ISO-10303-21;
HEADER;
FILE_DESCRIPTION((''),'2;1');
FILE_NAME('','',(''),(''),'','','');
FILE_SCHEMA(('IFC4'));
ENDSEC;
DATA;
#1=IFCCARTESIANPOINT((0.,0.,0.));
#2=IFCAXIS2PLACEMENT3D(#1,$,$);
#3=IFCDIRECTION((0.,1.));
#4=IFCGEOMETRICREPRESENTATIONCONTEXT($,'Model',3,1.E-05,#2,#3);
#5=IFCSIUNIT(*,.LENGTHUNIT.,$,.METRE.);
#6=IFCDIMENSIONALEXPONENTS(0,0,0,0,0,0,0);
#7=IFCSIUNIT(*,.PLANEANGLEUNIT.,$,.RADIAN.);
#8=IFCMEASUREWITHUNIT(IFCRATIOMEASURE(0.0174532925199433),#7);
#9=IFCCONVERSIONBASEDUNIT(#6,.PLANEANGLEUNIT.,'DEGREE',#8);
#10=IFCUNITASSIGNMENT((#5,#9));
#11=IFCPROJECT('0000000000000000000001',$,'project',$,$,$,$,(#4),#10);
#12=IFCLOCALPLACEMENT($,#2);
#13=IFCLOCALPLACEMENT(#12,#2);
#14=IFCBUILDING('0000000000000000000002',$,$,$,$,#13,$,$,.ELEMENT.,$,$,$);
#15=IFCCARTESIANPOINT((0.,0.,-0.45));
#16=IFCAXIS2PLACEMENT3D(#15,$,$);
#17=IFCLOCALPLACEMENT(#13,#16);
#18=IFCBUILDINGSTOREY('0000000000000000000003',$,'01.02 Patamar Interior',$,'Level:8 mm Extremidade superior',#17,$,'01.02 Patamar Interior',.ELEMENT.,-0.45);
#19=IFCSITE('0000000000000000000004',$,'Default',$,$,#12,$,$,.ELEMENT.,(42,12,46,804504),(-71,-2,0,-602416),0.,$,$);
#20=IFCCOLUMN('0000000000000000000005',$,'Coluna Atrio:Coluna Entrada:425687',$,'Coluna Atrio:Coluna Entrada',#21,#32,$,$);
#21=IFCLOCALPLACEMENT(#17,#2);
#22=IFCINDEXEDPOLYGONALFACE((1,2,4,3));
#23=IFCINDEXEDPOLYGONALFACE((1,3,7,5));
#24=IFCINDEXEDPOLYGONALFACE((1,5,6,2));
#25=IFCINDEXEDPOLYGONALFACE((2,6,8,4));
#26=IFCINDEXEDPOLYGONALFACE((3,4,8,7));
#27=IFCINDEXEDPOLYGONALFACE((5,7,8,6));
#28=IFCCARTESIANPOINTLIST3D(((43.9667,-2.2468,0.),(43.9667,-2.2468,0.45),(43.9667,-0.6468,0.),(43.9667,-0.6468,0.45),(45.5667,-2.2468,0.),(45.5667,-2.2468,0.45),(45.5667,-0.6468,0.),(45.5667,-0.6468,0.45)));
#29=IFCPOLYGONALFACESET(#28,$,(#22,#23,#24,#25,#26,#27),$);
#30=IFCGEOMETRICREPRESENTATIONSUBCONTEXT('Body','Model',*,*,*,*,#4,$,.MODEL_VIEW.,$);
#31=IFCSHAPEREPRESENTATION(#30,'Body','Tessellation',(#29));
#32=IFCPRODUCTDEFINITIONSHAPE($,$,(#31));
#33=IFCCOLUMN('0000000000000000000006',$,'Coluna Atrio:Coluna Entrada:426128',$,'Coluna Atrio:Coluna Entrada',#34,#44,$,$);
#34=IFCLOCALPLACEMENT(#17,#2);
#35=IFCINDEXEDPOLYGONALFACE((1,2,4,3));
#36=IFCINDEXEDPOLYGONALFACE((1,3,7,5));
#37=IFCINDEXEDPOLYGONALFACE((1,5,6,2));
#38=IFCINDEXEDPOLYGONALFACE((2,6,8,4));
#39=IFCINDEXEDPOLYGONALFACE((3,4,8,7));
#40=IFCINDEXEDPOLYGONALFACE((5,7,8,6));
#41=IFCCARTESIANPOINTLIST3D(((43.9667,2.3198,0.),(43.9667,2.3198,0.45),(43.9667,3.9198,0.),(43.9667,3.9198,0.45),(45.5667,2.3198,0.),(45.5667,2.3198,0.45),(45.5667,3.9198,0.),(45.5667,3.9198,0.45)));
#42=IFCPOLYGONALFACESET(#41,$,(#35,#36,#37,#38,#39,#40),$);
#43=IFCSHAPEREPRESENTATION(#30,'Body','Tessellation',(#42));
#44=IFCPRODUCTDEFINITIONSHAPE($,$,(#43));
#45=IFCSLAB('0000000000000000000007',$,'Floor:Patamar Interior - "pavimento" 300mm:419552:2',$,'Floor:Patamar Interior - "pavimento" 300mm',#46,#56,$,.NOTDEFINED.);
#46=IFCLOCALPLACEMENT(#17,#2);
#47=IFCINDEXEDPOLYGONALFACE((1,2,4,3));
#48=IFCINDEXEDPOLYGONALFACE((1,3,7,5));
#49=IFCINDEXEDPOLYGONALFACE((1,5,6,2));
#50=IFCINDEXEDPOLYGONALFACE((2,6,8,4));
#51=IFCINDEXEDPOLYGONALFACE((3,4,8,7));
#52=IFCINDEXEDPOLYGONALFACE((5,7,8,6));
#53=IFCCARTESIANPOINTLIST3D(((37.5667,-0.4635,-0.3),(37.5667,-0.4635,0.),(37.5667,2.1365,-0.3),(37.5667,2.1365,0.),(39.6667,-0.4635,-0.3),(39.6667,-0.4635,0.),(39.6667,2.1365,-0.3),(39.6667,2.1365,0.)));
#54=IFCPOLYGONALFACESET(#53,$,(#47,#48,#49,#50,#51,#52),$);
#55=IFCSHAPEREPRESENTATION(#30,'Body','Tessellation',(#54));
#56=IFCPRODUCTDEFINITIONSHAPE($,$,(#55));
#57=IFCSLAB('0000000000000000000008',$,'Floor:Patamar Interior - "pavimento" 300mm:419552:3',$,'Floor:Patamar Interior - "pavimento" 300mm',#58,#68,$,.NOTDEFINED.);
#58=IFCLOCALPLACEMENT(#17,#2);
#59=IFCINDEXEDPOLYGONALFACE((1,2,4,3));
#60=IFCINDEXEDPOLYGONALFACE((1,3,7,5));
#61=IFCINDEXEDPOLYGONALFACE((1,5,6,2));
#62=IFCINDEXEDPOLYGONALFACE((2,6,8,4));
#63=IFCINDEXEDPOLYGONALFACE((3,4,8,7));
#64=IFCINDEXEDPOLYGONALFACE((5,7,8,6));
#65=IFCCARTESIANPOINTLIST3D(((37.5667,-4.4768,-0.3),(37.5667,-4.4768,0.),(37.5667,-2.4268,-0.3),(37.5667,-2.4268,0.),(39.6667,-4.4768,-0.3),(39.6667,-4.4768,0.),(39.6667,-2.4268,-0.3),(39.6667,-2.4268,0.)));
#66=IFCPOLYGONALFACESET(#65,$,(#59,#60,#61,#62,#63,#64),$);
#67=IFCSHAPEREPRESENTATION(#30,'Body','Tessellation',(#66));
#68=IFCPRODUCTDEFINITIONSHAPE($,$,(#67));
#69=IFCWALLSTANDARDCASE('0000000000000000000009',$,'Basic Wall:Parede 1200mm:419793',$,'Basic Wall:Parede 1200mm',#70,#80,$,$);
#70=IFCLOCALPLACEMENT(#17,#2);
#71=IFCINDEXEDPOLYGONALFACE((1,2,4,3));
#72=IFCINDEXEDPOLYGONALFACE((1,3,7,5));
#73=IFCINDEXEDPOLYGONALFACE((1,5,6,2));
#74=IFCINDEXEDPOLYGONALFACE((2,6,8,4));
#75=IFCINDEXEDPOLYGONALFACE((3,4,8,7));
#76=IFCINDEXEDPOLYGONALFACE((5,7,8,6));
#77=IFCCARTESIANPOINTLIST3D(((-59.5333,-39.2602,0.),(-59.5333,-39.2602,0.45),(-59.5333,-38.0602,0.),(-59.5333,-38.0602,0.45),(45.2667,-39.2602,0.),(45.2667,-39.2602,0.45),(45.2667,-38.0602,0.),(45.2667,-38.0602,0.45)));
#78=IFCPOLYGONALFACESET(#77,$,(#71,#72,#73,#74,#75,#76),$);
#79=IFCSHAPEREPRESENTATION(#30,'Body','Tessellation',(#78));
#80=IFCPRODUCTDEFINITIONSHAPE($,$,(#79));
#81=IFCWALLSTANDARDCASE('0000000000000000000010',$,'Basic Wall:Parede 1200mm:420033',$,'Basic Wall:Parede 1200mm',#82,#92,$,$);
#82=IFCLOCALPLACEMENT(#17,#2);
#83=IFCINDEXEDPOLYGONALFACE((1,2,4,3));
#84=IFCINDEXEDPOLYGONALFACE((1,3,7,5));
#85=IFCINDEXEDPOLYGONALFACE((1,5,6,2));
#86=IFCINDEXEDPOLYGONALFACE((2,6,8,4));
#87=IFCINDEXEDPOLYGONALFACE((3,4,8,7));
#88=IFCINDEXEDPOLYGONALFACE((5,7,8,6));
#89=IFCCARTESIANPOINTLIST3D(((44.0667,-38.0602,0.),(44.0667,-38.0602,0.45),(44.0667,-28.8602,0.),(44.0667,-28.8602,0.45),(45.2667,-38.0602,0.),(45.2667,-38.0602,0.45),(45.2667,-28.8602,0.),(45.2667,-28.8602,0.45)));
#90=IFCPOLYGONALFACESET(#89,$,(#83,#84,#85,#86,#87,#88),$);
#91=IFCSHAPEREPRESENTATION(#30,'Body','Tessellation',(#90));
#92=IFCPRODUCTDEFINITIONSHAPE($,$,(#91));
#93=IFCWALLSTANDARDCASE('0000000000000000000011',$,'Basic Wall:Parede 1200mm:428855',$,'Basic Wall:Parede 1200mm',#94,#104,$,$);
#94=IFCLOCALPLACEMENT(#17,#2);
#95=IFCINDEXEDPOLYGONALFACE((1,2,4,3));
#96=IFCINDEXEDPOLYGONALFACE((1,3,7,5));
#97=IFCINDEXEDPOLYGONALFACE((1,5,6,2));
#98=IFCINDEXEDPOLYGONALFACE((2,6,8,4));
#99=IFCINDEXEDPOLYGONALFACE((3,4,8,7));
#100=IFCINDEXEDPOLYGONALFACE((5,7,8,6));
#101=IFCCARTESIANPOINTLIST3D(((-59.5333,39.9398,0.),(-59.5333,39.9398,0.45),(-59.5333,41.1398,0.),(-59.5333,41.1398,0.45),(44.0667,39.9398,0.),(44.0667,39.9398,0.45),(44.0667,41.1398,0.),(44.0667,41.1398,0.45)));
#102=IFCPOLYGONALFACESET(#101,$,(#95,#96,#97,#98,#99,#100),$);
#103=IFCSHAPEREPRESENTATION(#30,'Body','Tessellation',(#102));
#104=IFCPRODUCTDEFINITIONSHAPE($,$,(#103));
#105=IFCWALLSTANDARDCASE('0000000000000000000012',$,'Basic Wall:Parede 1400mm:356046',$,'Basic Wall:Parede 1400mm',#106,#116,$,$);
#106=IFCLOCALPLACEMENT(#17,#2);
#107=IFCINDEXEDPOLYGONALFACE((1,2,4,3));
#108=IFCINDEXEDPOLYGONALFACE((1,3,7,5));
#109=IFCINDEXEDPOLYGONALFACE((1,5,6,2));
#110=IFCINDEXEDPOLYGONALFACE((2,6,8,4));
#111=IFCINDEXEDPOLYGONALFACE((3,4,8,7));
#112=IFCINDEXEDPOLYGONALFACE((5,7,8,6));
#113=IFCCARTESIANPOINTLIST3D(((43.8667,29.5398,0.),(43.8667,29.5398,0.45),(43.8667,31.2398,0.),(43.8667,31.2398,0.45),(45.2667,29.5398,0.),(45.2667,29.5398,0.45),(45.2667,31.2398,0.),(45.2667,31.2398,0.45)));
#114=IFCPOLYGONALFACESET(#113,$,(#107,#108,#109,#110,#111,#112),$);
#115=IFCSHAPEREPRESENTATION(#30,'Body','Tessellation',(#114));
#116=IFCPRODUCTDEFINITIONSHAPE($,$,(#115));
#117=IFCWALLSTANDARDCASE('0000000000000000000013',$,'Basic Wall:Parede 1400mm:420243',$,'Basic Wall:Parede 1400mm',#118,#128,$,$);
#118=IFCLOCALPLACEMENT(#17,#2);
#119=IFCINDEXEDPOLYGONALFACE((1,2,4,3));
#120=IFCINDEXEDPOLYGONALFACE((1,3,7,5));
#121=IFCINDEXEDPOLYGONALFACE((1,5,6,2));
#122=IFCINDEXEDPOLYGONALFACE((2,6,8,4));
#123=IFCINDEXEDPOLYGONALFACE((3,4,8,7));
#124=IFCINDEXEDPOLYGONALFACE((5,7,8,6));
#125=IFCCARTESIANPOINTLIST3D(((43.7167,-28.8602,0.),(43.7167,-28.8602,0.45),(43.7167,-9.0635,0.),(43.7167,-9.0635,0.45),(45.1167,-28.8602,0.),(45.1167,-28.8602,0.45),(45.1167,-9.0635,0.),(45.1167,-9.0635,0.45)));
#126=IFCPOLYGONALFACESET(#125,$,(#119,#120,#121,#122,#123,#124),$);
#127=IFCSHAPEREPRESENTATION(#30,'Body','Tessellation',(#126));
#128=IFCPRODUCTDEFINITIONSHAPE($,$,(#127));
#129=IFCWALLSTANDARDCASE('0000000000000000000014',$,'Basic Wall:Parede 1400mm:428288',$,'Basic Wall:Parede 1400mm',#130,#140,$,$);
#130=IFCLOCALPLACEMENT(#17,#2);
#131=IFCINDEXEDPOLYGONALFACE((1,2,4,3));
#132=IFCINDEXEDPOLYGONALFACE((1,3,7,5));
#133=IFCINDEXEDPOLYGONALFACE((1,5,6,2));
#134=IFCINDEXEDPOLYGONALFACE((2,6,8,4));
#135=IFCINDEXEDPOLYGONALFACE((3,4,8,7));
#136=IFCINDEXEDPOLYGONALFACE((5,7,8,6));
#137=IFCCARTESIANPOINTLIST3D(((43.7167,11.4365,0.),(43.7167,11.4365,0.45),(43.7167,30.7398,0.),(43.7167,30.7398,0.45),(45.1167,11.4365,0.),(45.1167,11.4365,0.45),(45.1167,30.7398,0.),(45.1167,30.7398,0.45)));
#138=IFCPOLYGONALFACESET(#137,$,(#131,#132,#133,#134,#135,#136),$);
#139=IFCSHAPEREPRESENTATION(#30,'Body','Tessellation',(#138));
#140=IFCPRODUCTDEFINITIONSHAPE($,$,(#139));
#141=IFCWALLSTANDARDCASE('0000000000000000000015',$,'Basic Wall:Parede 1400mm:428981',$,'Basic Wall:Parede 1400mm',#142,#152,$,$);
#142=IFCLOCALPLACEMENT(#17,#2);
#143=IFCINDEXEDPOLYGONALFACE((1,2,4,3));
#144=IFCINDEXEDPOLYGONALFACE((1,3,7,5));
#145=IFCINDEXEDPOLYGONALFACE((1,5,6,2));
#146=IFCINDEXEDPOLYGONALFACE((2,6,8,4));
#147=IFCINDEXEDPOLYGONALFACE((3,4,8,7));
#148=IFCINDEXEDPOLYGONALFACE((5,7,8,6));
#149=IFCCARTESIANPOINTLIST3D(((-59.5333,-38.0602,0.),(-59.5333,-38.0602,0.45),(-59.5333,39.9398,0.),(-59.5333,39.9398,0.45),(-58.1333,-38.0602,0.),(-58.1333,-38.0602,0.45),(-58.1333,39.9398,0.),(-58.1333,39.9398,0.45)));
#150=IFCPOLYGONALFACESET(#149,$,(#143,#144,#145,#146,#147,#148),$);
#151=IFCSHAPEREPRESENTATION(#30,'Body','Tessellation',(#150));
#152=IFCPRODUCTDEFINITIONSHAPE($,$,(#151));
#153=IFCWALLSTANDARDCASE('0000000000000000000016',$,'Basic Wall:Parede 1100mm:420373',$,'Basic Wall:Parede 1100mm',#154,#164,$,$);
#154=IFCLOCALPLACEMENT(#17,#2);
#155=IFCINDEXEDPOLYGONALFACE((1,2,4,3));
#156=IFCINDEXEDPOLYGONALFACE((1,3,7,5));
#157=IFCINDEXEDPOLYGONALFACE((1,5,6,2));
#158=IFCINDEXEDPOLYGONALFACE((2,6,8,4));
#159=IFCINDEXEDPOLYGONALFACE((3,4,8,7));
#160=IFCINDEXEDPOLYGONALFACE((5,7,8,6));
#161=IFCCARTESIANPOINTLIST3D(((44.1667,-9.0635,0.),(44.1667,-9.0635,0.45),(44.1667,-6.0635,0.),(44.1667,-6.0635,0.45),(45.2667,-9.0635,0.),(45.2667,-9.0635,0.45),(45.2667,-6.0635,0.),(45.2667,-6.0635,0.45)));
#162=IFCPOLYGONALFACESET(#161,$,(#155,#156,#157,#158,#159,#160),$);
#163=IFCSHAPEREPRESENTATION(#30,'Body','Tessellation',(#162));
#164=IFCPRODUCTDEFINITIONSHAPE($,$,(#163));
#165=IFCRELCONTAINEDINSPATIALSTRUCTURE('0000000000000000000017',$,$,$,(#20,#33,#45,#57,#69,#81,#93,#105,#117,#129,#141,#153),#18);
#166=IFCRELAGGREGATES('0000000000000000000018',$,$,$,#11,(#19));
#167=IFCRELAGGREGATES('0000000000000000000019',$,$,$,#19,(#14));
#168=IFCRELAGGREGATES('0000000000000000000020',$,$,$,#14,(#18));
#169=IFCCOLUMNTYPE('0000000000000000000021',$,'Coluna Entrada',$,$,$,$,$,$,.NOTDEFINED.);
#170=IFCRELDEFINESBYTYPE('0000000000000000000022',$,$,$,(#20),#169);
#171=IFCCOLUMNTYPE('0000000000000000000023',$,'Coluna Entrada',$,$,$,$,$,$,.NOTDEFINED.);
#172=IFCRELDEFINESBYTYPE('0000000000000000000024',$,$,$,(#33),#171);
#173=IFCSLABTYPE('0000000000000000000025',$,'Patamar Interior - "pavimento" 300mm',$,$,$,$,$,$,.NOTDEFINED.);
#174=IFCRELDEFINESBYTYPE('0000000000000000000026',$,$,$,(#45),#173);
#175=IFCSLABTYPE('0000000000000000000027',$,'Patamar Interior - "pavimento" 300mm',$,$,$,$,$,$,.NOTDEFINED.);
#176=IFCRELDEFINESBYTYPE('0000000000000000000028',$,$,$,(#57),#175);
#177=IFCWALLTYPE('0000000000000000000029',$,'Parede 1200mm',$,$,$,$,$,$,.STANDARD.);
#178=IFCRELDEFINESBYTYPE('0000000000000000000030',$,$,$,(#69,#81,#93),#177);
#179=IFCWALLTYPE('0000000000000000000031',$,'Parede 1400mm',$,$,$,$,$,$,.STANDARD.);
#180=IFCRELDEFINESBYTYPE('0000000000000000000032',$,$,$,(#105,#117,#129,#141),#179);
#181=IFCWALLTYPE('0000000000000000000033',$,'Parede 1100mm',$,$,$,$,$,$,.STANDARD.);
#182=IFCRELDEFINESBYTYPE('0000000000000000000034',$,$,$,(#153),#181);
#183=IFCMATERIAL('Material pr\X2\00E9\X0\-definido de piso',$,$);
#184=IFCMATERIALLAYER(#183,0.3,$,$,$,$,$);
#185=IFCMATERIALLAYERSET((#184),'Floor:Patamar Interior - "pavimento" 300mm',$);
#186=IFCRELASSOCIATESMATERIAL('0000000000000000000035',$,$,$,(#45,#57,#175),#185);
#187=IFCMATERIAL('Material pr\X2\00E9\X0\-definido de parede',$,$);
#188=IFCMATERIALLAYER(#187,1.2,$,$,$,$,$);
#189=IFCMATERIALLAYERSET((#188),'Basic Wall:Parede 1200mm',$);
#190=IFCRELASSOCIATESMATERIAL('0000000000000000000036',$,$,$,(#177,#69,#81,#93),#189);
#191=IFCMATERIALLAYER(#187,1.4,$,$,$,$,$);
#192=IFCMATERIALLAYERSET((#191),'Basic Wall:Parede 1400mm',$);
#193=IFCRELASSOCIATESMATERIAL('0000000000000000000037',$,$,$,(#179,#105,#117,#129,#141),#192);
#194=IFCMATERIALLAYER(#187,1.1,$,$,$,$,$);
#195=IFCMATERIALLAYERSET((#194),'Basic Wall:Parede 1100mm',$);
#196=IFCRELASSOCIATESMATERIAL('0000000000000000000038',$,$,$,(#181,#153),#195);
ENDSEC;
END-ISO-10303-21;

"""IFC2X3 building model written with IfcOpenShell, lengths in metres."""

from ifc_helpers import new_model, entity, si_unit, converted_unit, direction, frame, frame_2d, origin, origin_2d_with_axis, place, context, subcontext, project, spatial, rectangle, extrude, clip, halfspace, source, transform, mapped, material, layer, layer_set, layer_usage, type_object, type_shapes, element, save


model = new_model("IFC2X3")

# Units and contexts
model_context = context("Model", 3, precision=1e-05, world=origin(), true_north=direction((0.0, 1.0)))
body_context = subcontext(model_context, "Body", "Model", "MODEL_VIEW")
ifc_project = project(units=[si_unit("LENGTHUNIT", "METRE"), converted_unit("PLANEANGLEUNIT", "DEGREE", entity("IfcRatioMeasure", 0.0174532925199433), si_unit("PLANEANGLEUNIT", "RADIAN"), dimensions=[0, 0, 0, 0, 0, 0, 0])], contexts=[model_context])

# Site, building, storey
site_placement = place(None, origin())
site = spatial("IfcSite", under=ifc_project, at=site_placement, Name="Default", CompositionType="ELEMENT", RefLatitude=(42, 12, 46, 804504), RefLongitude=(-71, -2, 0, -602416), RefElevation=0.0)
building_placement = place(site_placement, origin())
building = spatial("IfcBuilding", under=site, at=building_placement, CompositionType="ELEMENT")
storey_placement = place(building_placement, frame((0.0, 0.0, -0.45)))
storey = spatial("IfcBuildingStorey", under=building, at=storey_placement, Name="01.02 Patamar Interior", ObjectType="Level:8 mm Extremidade superior", LongName="01.02 Patamar Interior", CompositionType="ELEMENT", Elevation=-0.45)

# Columns
column_type_1 = type_object("IfcColumnType", Name="Coluna Entrada", PredefinedType="NOTDEFINED")
shared_shape_1 = source(origin(), body_context, "Body", "SweptSolid", [
    extrude(rectangle(XDim=1.6, YDim=1.6, at=origin_2d_with_axis()), frame((0.0, 0.0, -0.45), z_axis=(0.0, 0.0, 1.0), x_axis=(0.0, -1.0, 0.0)), (0.0, 0.0, 1.0), 0.45),
])
type_shapes(column_type_1, [shared_shape_1])
column_1_placement = place(storey_placement, frame((44.7667, -1.4468, 0.45)))
element("IfcColumn", 1, at=column_1_placement, inside=storey, type_object=column_type_1, Name="Coluna Atrio:Coluna Entrada:425687", ObjectType="Coluna Atrio:Coluna Entrada", context=body_context, shape_type="MappedRepresentation", body=[
    mapped(shared_shape_1, transform((0.0, 0.0, 0.0), scale=1.0)),
])
column_type_2 = type_object("IfcColumnType", Name="Coluna Entrada", PredefinedType="NOTDEFINED")
shared_shape_2 = source(origin(), body_context, "Body", "SweptSolid", [
    extrude(rectangle(XDim=1.6, YDim=1.6, at=origin_2d_with_axis()), frame((0.0, 0.0, -0.45), z_axis=(0.0, 0.0, 1.0), x_axis=(0.0, -1.0, 0.0)), (0.0, 0.0, 1.0), 0.45),
])
type_shapes(column_type_2, [shared_shape_2])
column_2_placement = place(storey_placement, frame((44.7667, 3.1198, 0.45)))
element("IfcColumn", 2, at=column_2_placement, inside=storey, type_object=column_type_2, Name="Coluna Atrio:Coluna Entrada:426128", ObjectType="Coluna Atrio:Coluna Entrada", context=body_context, shape_type="MappedRepresentation", body=[
    mapped(shared_shape_2, transform((0.0, 0.0, 0.0), scale=1.0)),
])

# Slabs
ifc_material_1 = material(Name="Material pré-definido de piso")
ifc_layer_1 = layer(ifc_material_1, 0.3)
ifc_layer_set_1 = layer_set([ifc_layer_1], Name="Floor:Patamar Interior - \"pavimento\" 300mm")
ifc_layer_usage_1 = layer_usage(ifc_layer_set_1, "AXIS3", "POSITIVE", 0.0)
slab_type_1 = type_object("IfcSlabType", Name="Patamar Interior - \"pavimento\" 300mm", PredefinedType="NOTDEFINED")
slab_1_placement = place(storey_placement, frame((37.5667, -4.4768, -0.3)))
element("IfcSlab", 3, at=slab_1_placement, inside=storey, type_object=slab_type_1, material=ifc_layer_usage_1, Name="Floor:Patamar Interior - \"pavimento\" 300mm:419552:2", ObjectType="Floor:Patamar Interior - \"pavimento\" 300mm", PredefinedType="NOTDEFINED", context=body_context, shape_type="SweptSolid", body=[
    extrude(rectangle(XDim=2.6, YDim=2.1, at=frame_2d((0.0, 0.0), x_axis=(0.0, -1.0))), frame((1.05, 5.3133, 0.3), z_axis=(0.0, 0.0, -1.0), x_axis=(-1.0, 0.0, 0.0)), (0.0, 0.0, 1.0), 0.3),
])
slab_type_2 = type_object("IfcSlabType", Name="Patamar Interior - \"pavimento\" 300mm", PredefinedType="NOTDEFINED", material=ifc_layer_set_1)
slab_2_placement = place(storey_placement, frame((37.5667, -4.4768, -0.3)))
element("IfcSlab", 4, at=slab_2_placement, inside=storey, type_object=slab_type_2, material=ifc_layer_usage_1, Name="Floor:Patamar Interior - \"pavimento\" 300mm:419552:3", ObjectType="Floor:Patamar Interior - \"pavimento\" 300mm", PredefinedType="NOTDEFINED", context=body_context, shape_type="SweptSolid", body=[
    extrude(rectangle(XDim=2.05, YDim=2.1, at=frame_2d((0.0, -4.2883), x_axis=(0.0, -1.0))), frame((1.05, 5.3133, 0.3), z_axis=(0.0, 0.0, -1.0), x_axis=(-1.0, 0.0, 0.0)), (0.0, 0.0, 1.0), 0.3),
])

# Walls
ifc_material_2 = material(Name="Material pré-definido de parede")
ifc_layer_2 = layer(ifc_material_2, 1.2)
ifc_layer_set_2 = layer_set([ifc_layer_2], Name="Basic Wall:Parede 1200mm")
ifc_layer_usage_2 = layer_usage(ifc_layer_set_2, "AXIS2", "NEGATIVE", 0.6)
wall_type_1 = type_object("IfcWallType", Name="Parede 1200mm", PredefinedType="STANDARD", material=ifc_layer_set_2)
wall_1_placement = place(storey_placement, frame((45.2667, -38.6602, 0.0), z_axis=(0.0, 0.0, 1.0), x_axis=(-1.0, 0.0, 0.0)))
element("IfcWallStandardCase", 5, at=wall_1_placement, inside=storey, type_object=wall_type_1, material=ifc_layer_usage_2, Name="Basic Wall:Parede 1200mm:419793", ObjectType="Basic Wall:Parede 1200mm", context=body_context, shape_type="Clipping", body=[
    clip(extrude(rectangle(XDim=104.8, YDim=1.2, at=frame_2d((52.4, 0.0), x_axis=(-1.0, 0.0))), origin(), (0.0, 0.0, 1.0), 0.45), halfspace(frame((0.0, 0.0, -2.4)), True)),
])
ifc_layer_usage_3 = layer_usage(ifc_layer_set_2, "AXIS2", "POSITIVE", -0.6)
wall_2_placement = place(storey_placement, frame((44.6667, -38.0602, 0.0), z_axis=(0.0, 0.0, 1.0), x_axis=(0.0, 1.0, 0.0)))
element("IfcWallStandardCase", 6, at=wall_2_placement, inside=storey, type_object=wall_type_1, material=ifc_layer_usage_3, Name="Basic Wall:Parede 1200mm:420033", ObjectType="Basic Wall:Parede 1200mm", context=body_context, shape_type="Clipping", body=[
    clip(extrude(rectangle(XDim=9.2, YDim=1.2, at=frame_2d((4.6, 0.0), x_axis=(-1.0, 0.0))), origin(), (0.0, 0.0, 1.0), 0.45), halfspace(frame((0.0, 0.0, -2.4)), True)),
])
ifc_layer_usage_4 = layer_usage(ifc_layer_set_2, "AXIS2", "POSITIVE", -0.6)
wall_3_placement = place(storey_placement, frame((44.0667, 40.5398, 0.0), z_axis=(0.0, 0.0, 1.0), x_axis=(-1.0, 0.0, 0.0)))
element("IfcWallStandardCase", 7, at=wall_3_placement, inside=storey, type_object=wall_type_1, material=ifc_layer_usage_4, Name="Basic Wall:Parede 1200mm:428855", ObjectType="Basic Wall:Parede 1200mm", context=body_context, shape_type="Clipping", body=[
    clip(extrude(rectangle(XDim=103.6, YDim=1.2, at=frame_2d((51.8, 0.0), x_axis=(-1.0, 0.0))), origin(), (0.0, 0.0, 1.0), 0.45), halfspace(frame((0.0, 0.0, -2.4)), True)),
])
ifc_layer_3 = layer(ifc_material_2, 1.4)
ifc_layer_set_3 = layer_set([ifc_layer_3], Name="Basic Wall:Parede 1400mm")
ifc_layer_usage_5 = layer_usage(ifc_layer_set_3, "AXIS2", "POSITIVE", -0.7)
wall_type_2 = type_object("IfcWallType", Name="Parede 1400mm", PredefinedType="STANDARD", material=ifc_layer_set_3)
wall_4_placement = place(storey_placement, frame((44.5667, 31.2398, 0.0), z_axis=(0.0, 0.0, 1.0), x_axis=(0.0, -1.0, 0.0)))
element("IfcWallStandardCase", 8, at=wall_4_placement, inside=storey, type_object=wall_type_2, material=ifc_layer_usage_5, Name="Basic Wall:Parede 1400mm:356046", ObjectType="Basic Wall:Parede 1400mm", context=body_context, shape_type="Clipping", body=[
    clip(extrude(rectangle(XDim=1.7, YDim=1.4, at=frame_2d((0.85, 0.0), x_axis=(-1.0, 0.0))), origin(), (0.0, 0.0, 1.0), 0.45), halfspace(frame((0.0, 0.0, -2.4)), True)),
])
ifc_layer_usage_6 = layer_usage(ifc_layer_set_3, "AXIS2", "POSITIVE", -0.7)
wall_5_placement = place(storey_placement, frame((44.4167, -28.8602, 0.0), z_axis=(0.0, 0.0, 1.0), x_axis=(0.0, 1.0, 0.0)))
element("IfcWallStandardCase", 9, at=wall_5_placement, inside=storey, type_object=wall_type_2, material=ifc_layer_usage_6, Name="Basic Wall:Parede 1400mm:420243", ObjectType="Basic Wall:Parede 1400mm", context=body_context, shape_type="Clipping", body=[
    clip(extrude(rectangle(XDim=19.7967, YDim=1.4, at=frame_2d((9.8983, 0.0), x_axis=(-1.0, 0.0))), origin(), (0.0, 0.0, 1.0), 0.45), halfspace(frame((0.0, 0.0, -2.4)), True)),
])
ifc_layer_usage_7 = layer_usage(ifc_layer_set_3, "AXIS2", "POSITIVE", -0.7)
wall_6_placement = place(storey_placement, frame((44.4167, 11.4365, 0.0), z_axis=(0.0, 0.0, 1.0), x_axis=(0.0, 1.0, 0.0)))
element("IfcWallStandardCase", 10, at=wall_6_placement, inside=storey, type_object=wall_type_2, material=ifc_layer_usage_7, Name="Basic Wall:Parede 1400mm:428288", ObjectType="Basic Wall:Parede 1400mm", context=body_context, shape_type="Clipping", body=[
    clip(extrude(rectangle(XDim=19.3033, YDim=1.4, at=frame_2d((9.6517, 0.0), x_axis=(-1.0, 0.0))), origin(), (0.0, 0.0, 1.0), 0.45), halfspace(frame((0.0, 0.0, -2.4)), True)),
])
ifc_layer_usage_8 = layer_usage(ifc_layer_set_3, "AXIS2", "NEGATIVE", 0.7)
wall_7_placement = place(storey_placement, frame((-58.8333, 39.9398, 0.0), z_axis=(0.0, 0.0, 1.0), x_axis=(0.0, -1.0, 0.0)))
element("IfcWallStandardCase", 11, at=wall_7_placement, inside=storey, type_object=wall_type_2, material=ifc_layer_usage_8, Name="Basic Wall:Parede 1400mm:428981", ObjectType="Basic Wall:Parede 1400mm", context=body_context, shape_type="Clipping", body=[
    clip(extrude(rectangle(XDim=78.0, YDim=1.4, at=frame_2d((39.0, 0.0), x_axis=(-1.0, 0.0))), origin(), (0.0, 0.0, 1.0), 0.45), halfspace(frame((0.0, 0.0, -2.4)), True)),
])
ifc_layer_4 = layer(ifc_material_2, 1.1)
ifc_layer_set_4 = layer_set([ifc_layer_4], Name="Basic Wall:Parede 1100mm")
ifc_layer_usage_9 = layer_usage(ifc_layer_set_4, "AXIS2", "POSITIVE", -0.55)
wall_type_3 = type_object("IfcWallType", Name="Parede 1100mm", PredefinedType="STANDARD", material=ifc_layer_set_4)
wall_8_placement = place(storey_placement, frame((44.7167, -9.0635, 0.0), z_axis=(0.0, 0.0, 1.0), x_axis=(0.0, 1.0, 0.0)))
element("IfcWallStandardCase", 12, at=wall_8_placement, inside=storey, type_object=wall_type_3, material=ifc_layer_usage_9, Name="Basic Wall:Parede 1100mm:420373", ObjectType="Basic Wall:Parede 1100mm", context=body_context, shape_type="Clipping", body=[
    clip(extrude(rectangle(XDim=3.0, YDim=1.1, at=frame_2d((1.5, 0.0), x_axis=(-1.0, 0.0))), origin(), (0.0, 0.0, 1.0), 0.45), halfspace(frame((0.0, 0.0, -2.4)), True)),
])

save(model, "model.ifc")
